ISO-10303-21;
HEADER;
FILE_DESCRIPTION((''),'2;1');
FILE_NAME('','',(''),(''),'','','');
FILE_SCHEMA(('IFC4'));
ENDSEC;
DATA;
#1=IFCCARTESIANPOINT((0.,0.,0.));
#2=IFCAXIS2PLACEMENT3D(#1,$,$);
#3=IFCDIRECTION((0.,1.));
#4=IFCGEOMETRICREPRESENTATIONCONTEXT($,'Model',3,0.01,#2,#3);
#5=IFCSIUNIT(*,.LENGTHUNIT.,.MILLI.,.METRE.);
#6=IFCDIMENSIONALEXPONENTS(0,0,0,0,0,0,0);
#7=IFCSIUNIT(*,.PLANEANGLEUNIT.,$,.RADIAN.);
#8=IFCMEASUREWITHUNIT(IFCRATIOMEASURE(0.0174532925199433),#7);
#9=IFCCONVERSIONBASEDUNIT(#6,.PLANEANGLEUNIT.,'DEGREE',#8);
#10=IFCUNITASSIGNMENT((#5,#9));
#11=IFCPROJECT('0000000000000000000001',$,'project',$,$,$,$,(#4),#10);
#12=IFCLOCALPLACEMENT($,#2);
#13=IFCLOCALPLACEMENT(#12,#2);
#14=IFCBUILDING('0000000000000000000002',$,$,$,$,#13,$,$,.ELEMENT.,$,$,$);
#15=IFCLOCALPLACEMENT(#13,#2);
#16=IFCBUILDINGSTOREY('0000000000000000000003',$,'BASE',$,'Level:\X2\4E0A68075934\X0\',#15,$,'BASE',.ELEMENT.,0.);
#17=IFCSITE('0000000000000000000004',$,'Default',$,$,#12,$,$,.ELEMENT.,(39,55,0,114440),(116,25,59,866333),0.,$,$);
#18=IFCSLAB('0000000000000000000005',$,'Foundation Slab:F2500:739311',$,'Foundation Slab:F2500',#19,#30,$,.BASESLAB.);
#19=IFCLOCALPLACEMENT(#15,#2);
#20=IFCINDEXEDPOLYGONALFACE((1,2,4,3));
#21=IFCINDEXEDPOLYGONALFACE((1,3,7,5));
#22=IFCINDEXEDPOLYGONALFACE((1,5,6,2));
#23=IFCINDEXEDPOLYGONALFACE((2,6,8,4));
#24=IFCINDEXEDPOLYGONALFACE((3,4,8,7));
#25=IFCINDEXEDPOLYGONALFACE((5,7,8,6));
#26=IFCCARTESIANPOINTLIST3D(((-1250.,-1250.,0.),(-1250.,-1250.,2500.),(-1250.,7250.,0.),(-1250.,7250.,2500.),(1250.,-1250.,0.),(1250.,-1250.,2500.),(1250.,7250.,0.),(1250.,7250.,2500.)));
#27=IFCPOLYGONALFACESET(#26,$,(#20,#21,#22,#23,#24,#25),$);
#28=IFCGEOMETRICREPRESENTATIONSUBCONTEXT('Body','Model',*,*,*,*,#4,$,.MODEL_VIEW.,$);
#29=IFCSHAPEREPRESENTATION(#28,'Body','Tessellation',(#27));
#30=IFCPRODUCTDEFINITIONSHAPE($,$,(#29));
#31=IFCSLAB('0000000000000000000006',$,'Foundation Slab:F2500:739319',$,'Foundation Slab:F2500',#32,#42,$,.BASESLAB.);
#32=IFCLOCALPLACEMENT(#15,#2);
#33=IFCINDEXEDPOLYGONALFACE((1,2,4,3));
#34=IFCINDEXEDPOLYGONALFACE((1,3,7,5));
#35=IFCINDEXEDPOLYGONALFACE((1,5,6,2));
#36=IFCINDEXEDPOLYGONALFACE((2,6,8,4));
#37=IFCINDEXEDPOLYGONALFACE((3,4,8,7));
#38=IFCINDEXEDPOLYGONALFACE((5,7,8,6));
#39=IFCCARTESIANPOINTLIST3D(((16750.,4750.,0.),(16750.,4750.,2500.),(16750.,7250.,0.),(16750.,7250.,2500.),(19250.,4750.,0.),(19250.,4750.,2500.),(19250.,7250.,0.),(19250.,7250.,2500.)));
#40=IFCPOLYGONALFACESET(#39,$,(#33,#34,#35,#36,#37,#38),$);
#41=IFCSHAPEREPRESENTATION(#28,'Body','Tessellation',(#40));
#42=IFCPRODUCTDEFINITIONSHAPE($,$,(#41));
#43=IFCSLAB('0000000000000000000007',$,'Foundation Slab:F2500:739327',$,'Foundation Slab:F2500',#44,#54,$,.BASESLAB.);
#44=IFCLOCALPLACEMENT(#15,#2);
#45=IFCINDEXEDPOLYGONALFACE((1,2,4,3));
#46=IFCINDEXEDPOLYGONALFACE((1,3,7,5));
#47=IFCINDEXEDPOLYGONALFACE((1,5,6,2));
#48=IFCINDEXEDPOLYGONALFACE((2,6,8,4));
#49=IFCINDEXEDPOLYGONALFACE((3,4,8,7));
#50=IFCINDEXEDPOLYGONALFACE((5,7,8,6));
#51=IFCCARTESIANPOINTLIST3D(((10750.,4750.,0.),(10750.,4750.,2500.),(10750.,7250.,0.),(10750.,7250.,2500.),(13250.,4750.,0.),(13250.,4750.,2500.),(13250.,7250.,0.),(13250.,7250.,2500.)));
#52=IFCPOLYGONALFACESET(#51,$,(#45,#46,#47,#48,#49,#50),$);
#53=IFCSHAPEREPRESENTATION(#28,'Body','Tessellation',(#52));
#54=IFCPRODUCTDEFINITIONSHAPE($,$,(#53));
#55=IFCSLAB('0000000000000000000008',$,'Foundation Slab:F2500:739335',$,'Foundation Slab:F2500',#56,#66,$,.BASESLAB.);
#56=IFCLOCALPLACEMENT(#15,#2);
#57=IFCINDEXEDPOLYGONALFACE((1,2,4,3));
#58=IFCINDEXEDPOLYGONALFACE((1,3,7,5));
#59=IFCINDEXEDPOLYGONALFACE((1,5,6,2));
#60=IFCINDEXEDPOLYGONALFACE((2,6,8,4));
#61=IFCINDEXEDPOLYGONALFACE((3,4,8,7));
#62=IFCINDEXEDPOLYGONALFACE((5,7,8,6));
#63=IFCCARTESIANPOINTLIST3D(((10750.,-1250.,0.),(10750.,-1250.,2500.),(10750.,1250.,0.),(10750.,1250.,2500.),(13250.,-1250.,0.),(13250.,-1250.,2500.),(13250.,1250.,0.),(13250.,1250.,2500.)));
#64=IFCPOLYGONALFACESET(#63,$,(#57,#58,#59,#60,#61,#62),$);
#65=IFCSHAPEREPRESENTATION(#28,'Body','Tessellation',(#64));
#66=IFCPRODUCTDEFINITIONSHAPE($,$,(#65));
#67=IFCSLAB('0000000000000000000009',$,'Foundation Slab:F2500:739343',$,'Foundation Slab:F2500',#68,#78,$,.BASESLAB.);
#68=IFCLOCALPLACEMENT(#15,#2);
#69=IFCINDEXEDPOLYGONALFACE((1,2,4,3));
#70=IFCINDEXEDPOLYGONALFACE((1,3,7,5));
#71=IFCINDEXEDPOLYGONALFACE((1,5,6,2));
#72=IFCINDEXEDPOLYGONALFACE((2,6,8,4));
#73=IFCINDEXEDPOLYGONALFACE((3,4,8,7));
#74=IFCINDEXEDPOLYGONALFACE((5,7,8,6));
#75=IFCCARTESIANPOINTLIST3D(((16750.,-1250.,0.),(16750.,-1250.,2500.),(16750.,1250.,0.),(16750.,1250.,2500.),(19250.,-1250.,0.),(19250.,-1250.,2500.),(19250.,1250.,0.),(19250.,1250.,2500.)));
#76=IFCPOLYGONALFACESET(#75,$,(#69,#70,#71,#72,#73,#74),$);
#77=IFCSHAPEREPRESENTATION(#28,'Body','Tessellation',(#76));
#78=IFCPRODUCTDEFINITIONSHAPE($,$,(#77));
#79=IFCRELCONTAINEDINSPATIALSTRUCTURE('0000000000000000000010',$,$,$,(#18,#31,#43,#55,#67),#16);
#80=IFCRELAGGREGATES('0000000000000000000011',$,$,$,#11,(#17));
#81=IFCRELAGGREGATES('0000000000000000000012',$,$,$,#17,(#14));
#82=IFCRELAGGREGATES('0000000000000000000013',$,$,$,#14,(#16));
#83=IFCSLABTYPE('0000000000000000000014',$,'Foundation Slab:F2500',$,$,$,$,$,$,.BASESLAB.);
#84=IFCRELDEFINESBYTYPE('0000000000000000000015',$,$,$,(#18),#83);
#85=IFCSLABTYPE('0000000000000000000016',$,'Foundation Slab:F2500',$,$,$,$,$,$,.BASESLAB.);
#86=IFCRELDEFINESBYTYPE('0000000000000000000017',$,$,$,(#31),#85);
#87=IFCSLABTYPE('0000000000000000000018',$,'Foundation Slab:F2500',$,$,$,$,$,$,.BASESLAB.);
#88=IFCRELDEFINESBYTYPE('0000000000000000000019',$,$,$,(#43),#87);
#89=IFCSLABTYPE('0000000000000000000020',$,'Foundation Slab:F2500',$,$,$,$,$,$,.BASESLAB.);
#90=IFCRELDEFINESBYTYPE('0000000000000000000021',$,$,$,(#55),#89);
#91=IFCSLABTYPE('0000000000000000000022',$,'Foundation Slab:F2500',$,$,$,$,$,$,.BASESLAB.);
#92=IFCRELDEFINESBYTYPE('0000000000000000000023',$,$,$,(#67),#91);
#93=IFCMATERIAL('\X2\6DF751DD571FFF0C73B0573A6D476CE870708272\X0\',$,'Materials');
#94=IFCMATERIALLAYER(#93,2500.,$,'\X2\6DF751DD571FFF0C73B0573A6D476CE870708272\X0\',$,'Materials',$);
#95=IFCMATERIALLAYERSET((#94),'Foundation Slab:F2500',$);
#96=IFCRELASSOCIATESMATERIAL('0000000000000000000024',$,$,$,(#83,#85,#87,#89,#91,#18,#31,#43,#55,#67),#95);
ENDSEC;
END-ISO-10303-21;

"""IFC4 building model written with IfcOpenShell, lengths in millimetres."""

from ifc_helpers import new_model, entity, si_unit, converted_unit, direction, frame, origin, origin_2d_with_axis, place, context, subcontext, project, spatial, rectangle, extrude, material, layer, layer_set, layer_usage, type_object, element, save


model = new_model("IFC4")

# Units and contexts
model_context = context("Model", 3, precision=0.01, world=origin(), true_north=direction((0.0, 1.0)))
body_context = subcontext(model_context, "Body", "Model", "MODEL_VIEW")
ifc_project = project(units=[si_unit("LENGTHUNIT", "METRE", prefix="MILLI"), converted_unit("PLANEANGLEUNIT", "DEGREE", entity("IfcRatioMeasure", 0.0174532925199433), si_unit("PLANEANGLEUNIT", "RADIAN"), dimensions=[0, 0, 0, 0, 0, 0, 0])], contexts=[model_context])

# Site, building, storey
site_placement = place(None, origin())
site = spatial("IfcSite", under=ifc_project, at=site_placement, Name="Default", CompositionType="ELEMENT", RefLatitude=(39, 55, 0, 114440), RefLongitude=(116, 25, 59, 866333), RefElevation=0.0)
building_placement = place(site_placement, origin())
building = spatial("IfcBuilding", under=site, at=building_placement, CompositionType="ELEMENT")
storey_placement = place(building_placement, origin())
storey = spatial("IfcBuildingStorey", under=building, at=storey_placement, Name="BASE", ObjectType="Level:上标头", LongName="BASE", CompositionType="ELEMENT", Elevation=0.0)

# Slabs
ifc_material = material(Name="混凝土，现场浇注灰色", Category="Materials")
ifc_layer = layer(ifc_material, 2500.0, Name="混凝土，现场浇注灰色", Category="Materials")
ifc_layer_set = layer_set([ifc_layer], Name="Foundation Slab:F2500")
ifc_layer_usage_1 = layer_usage(ifc_layer_set, "AXIS3", "POSITIVE", 0.0)
slab_type_1 = type_object("IfcSlabType", Name="Foundation Slab:F2500", PredefinedType="BASESLAB", material=ifc_layer_set)
slab_1_placement = place(storey_placement, origin())
element("IfcSlab", 1, at=slab_1_placement, inside=storey, type_object=slab_type_1, material=ifc_layer_usage_1, Name="Foundation Slab:F2500:739311", ObjectType="Foundation Slab:F2500", PredefinedType="BASESLAB", context=body_context, shape_type="SweptSolid", body=[
    extrude(rectangle(XDim=8500.0, YDim=2500.0, at=origin_2d_with_axis()), frame((0.0, 3000.0, 2500.0), z_axis=(0.0, 0.0, -1.0), x_axis=(0.0, 1.0, 0.0)), (0.0, 0.0, 1.0), 2500.0),
])
ifc_layer_usage_2 = layer_usage(ifc_layer_set, "AXIS3", "POSITIVE", 0.0)
slab_type_2 = type_object("IfcSlabType", Name="Foundation Slab:F2500", PredefinedType="BASESLAB", material=ifc_layer_set)
slab_2_placement = place(storey_placement, origin())
element("IfcSlab", 2, at=slab_2_placement, inside=storey, type_object=slab_type_2, material=ifc_layer_usage_2, Name="Foundation Slab:F2500:739319", ObjectType="Foundation Slab:F2500", PredefinedType="BASESLAB", context=body_context, shape_type="SweptSolid", body=[
    extrude(rectangle(XDim=2500.0, YDim=2500.0, at=origin_2d_with_axis()), frame((18000.0, 6000.0, 2500.0), z_axis=(0.0, 0.0, -1.0), x_axis=(0.0, 1.0, 0.0)), (0.0, 0.0, 1.0), 2500.0),
])
ifc_layer_usage_3 = layer_usage(ifc_layer_set, "AXIS3", "POSITIVE", 0.0)
slab_type_3 = type_object("IfcSlabType", Name="Foundation Slab:F2500", PredefinedType="BASESLAB", material=ifc_layer_set)
slab_3_placement = place(storey_placement, origin())
element("IfcSlab", 3, at=slab_3_placement, inside=storey, type_object=slab_type_3, material=ifc_layer_usage_3, Name="Foundation Slab:F2500:739327", ObjectType="Foundation Slab:F2500", PredefinedType="BASESLAB", context=body_context, shape_type="SweptSolid", body=[
    extrude(rectangle(XDim=2500.0, YDim=2500.0, at=origin_2d_with_axis()), frame((12000.0, 6000.0, 2500.0), z_axis=(0.0, 0.0, -1.0), x_axis=(0.0, 1.0, 0.0)), (0.0, 0.0, 1.0), 2500.0),
])
ifc_layer_usage_4 = layer_usage(ifc_layer_set, "AXIS3", "POSITIVE", 0.0)
slab_type_4 = type_object("IfcSlabType", Name="Foundation Slab:F2500", PredefinedType="BASESLAB", material=ifc_layer_set)
slab_4_placement = place(storey_placement, origin())
element("IfcSlab", 4, at=slab_4_placement, inside=storey, type_object=slab_type_4, material=ifc_layer_usage_4, Name="Foundation Slab:F2500:739335", ObjectType="Foundation Slab:F2500", PredefinedType="BASESLAB", context=body_context, shape_type="SweptSolid", body=[
    extrude(rectangle(XDim=2500.0, YDim=2500.0, at=origin_2d_with_axis()), frame((12000.0, 0.0, 2500.0), z_axis=(0.0, 0.0, -1.0), x_axis=(0.0, 1.0, 0.0)), (0.0, 0.0, 1.0), 2500.0),
])
ifc_layer_usage_5 = layer_usage(ifc_layer_set, "AXIS3", "POSITIVE", 0.0)
slab_type_5 = type_object("IfcSlabType", Name="Foundation Slab:F2500", PredefinedType="BASESLAB", material=ifc_layer_set)
slab_5_placement = place(storey_placement, origin())
element("IfcSlab", 5, at=slab_5_placement, inside=storey, type_object=slab_type_5, material=ifc_layer_usage_5, Name="Foundation Slab:F2500:739343", ObjectType="Foundation Slab:F2500", PredefinedType="BASESLAB", context=body_context, shape_type="SweptSolid", body=[
    extrude(rectangle(XDim=2500.0, YDim=2500.0, at=origin_2d_with_axis()), frame((18000.0, 0.0, 2500.0), z_axis=(0.0, 0.0, -1.0), x_axis=(0.0, 1.0, 0.0)), (0.0, 0.0, 1.0), 2500.0),
])

save(model, "model.ifc")
